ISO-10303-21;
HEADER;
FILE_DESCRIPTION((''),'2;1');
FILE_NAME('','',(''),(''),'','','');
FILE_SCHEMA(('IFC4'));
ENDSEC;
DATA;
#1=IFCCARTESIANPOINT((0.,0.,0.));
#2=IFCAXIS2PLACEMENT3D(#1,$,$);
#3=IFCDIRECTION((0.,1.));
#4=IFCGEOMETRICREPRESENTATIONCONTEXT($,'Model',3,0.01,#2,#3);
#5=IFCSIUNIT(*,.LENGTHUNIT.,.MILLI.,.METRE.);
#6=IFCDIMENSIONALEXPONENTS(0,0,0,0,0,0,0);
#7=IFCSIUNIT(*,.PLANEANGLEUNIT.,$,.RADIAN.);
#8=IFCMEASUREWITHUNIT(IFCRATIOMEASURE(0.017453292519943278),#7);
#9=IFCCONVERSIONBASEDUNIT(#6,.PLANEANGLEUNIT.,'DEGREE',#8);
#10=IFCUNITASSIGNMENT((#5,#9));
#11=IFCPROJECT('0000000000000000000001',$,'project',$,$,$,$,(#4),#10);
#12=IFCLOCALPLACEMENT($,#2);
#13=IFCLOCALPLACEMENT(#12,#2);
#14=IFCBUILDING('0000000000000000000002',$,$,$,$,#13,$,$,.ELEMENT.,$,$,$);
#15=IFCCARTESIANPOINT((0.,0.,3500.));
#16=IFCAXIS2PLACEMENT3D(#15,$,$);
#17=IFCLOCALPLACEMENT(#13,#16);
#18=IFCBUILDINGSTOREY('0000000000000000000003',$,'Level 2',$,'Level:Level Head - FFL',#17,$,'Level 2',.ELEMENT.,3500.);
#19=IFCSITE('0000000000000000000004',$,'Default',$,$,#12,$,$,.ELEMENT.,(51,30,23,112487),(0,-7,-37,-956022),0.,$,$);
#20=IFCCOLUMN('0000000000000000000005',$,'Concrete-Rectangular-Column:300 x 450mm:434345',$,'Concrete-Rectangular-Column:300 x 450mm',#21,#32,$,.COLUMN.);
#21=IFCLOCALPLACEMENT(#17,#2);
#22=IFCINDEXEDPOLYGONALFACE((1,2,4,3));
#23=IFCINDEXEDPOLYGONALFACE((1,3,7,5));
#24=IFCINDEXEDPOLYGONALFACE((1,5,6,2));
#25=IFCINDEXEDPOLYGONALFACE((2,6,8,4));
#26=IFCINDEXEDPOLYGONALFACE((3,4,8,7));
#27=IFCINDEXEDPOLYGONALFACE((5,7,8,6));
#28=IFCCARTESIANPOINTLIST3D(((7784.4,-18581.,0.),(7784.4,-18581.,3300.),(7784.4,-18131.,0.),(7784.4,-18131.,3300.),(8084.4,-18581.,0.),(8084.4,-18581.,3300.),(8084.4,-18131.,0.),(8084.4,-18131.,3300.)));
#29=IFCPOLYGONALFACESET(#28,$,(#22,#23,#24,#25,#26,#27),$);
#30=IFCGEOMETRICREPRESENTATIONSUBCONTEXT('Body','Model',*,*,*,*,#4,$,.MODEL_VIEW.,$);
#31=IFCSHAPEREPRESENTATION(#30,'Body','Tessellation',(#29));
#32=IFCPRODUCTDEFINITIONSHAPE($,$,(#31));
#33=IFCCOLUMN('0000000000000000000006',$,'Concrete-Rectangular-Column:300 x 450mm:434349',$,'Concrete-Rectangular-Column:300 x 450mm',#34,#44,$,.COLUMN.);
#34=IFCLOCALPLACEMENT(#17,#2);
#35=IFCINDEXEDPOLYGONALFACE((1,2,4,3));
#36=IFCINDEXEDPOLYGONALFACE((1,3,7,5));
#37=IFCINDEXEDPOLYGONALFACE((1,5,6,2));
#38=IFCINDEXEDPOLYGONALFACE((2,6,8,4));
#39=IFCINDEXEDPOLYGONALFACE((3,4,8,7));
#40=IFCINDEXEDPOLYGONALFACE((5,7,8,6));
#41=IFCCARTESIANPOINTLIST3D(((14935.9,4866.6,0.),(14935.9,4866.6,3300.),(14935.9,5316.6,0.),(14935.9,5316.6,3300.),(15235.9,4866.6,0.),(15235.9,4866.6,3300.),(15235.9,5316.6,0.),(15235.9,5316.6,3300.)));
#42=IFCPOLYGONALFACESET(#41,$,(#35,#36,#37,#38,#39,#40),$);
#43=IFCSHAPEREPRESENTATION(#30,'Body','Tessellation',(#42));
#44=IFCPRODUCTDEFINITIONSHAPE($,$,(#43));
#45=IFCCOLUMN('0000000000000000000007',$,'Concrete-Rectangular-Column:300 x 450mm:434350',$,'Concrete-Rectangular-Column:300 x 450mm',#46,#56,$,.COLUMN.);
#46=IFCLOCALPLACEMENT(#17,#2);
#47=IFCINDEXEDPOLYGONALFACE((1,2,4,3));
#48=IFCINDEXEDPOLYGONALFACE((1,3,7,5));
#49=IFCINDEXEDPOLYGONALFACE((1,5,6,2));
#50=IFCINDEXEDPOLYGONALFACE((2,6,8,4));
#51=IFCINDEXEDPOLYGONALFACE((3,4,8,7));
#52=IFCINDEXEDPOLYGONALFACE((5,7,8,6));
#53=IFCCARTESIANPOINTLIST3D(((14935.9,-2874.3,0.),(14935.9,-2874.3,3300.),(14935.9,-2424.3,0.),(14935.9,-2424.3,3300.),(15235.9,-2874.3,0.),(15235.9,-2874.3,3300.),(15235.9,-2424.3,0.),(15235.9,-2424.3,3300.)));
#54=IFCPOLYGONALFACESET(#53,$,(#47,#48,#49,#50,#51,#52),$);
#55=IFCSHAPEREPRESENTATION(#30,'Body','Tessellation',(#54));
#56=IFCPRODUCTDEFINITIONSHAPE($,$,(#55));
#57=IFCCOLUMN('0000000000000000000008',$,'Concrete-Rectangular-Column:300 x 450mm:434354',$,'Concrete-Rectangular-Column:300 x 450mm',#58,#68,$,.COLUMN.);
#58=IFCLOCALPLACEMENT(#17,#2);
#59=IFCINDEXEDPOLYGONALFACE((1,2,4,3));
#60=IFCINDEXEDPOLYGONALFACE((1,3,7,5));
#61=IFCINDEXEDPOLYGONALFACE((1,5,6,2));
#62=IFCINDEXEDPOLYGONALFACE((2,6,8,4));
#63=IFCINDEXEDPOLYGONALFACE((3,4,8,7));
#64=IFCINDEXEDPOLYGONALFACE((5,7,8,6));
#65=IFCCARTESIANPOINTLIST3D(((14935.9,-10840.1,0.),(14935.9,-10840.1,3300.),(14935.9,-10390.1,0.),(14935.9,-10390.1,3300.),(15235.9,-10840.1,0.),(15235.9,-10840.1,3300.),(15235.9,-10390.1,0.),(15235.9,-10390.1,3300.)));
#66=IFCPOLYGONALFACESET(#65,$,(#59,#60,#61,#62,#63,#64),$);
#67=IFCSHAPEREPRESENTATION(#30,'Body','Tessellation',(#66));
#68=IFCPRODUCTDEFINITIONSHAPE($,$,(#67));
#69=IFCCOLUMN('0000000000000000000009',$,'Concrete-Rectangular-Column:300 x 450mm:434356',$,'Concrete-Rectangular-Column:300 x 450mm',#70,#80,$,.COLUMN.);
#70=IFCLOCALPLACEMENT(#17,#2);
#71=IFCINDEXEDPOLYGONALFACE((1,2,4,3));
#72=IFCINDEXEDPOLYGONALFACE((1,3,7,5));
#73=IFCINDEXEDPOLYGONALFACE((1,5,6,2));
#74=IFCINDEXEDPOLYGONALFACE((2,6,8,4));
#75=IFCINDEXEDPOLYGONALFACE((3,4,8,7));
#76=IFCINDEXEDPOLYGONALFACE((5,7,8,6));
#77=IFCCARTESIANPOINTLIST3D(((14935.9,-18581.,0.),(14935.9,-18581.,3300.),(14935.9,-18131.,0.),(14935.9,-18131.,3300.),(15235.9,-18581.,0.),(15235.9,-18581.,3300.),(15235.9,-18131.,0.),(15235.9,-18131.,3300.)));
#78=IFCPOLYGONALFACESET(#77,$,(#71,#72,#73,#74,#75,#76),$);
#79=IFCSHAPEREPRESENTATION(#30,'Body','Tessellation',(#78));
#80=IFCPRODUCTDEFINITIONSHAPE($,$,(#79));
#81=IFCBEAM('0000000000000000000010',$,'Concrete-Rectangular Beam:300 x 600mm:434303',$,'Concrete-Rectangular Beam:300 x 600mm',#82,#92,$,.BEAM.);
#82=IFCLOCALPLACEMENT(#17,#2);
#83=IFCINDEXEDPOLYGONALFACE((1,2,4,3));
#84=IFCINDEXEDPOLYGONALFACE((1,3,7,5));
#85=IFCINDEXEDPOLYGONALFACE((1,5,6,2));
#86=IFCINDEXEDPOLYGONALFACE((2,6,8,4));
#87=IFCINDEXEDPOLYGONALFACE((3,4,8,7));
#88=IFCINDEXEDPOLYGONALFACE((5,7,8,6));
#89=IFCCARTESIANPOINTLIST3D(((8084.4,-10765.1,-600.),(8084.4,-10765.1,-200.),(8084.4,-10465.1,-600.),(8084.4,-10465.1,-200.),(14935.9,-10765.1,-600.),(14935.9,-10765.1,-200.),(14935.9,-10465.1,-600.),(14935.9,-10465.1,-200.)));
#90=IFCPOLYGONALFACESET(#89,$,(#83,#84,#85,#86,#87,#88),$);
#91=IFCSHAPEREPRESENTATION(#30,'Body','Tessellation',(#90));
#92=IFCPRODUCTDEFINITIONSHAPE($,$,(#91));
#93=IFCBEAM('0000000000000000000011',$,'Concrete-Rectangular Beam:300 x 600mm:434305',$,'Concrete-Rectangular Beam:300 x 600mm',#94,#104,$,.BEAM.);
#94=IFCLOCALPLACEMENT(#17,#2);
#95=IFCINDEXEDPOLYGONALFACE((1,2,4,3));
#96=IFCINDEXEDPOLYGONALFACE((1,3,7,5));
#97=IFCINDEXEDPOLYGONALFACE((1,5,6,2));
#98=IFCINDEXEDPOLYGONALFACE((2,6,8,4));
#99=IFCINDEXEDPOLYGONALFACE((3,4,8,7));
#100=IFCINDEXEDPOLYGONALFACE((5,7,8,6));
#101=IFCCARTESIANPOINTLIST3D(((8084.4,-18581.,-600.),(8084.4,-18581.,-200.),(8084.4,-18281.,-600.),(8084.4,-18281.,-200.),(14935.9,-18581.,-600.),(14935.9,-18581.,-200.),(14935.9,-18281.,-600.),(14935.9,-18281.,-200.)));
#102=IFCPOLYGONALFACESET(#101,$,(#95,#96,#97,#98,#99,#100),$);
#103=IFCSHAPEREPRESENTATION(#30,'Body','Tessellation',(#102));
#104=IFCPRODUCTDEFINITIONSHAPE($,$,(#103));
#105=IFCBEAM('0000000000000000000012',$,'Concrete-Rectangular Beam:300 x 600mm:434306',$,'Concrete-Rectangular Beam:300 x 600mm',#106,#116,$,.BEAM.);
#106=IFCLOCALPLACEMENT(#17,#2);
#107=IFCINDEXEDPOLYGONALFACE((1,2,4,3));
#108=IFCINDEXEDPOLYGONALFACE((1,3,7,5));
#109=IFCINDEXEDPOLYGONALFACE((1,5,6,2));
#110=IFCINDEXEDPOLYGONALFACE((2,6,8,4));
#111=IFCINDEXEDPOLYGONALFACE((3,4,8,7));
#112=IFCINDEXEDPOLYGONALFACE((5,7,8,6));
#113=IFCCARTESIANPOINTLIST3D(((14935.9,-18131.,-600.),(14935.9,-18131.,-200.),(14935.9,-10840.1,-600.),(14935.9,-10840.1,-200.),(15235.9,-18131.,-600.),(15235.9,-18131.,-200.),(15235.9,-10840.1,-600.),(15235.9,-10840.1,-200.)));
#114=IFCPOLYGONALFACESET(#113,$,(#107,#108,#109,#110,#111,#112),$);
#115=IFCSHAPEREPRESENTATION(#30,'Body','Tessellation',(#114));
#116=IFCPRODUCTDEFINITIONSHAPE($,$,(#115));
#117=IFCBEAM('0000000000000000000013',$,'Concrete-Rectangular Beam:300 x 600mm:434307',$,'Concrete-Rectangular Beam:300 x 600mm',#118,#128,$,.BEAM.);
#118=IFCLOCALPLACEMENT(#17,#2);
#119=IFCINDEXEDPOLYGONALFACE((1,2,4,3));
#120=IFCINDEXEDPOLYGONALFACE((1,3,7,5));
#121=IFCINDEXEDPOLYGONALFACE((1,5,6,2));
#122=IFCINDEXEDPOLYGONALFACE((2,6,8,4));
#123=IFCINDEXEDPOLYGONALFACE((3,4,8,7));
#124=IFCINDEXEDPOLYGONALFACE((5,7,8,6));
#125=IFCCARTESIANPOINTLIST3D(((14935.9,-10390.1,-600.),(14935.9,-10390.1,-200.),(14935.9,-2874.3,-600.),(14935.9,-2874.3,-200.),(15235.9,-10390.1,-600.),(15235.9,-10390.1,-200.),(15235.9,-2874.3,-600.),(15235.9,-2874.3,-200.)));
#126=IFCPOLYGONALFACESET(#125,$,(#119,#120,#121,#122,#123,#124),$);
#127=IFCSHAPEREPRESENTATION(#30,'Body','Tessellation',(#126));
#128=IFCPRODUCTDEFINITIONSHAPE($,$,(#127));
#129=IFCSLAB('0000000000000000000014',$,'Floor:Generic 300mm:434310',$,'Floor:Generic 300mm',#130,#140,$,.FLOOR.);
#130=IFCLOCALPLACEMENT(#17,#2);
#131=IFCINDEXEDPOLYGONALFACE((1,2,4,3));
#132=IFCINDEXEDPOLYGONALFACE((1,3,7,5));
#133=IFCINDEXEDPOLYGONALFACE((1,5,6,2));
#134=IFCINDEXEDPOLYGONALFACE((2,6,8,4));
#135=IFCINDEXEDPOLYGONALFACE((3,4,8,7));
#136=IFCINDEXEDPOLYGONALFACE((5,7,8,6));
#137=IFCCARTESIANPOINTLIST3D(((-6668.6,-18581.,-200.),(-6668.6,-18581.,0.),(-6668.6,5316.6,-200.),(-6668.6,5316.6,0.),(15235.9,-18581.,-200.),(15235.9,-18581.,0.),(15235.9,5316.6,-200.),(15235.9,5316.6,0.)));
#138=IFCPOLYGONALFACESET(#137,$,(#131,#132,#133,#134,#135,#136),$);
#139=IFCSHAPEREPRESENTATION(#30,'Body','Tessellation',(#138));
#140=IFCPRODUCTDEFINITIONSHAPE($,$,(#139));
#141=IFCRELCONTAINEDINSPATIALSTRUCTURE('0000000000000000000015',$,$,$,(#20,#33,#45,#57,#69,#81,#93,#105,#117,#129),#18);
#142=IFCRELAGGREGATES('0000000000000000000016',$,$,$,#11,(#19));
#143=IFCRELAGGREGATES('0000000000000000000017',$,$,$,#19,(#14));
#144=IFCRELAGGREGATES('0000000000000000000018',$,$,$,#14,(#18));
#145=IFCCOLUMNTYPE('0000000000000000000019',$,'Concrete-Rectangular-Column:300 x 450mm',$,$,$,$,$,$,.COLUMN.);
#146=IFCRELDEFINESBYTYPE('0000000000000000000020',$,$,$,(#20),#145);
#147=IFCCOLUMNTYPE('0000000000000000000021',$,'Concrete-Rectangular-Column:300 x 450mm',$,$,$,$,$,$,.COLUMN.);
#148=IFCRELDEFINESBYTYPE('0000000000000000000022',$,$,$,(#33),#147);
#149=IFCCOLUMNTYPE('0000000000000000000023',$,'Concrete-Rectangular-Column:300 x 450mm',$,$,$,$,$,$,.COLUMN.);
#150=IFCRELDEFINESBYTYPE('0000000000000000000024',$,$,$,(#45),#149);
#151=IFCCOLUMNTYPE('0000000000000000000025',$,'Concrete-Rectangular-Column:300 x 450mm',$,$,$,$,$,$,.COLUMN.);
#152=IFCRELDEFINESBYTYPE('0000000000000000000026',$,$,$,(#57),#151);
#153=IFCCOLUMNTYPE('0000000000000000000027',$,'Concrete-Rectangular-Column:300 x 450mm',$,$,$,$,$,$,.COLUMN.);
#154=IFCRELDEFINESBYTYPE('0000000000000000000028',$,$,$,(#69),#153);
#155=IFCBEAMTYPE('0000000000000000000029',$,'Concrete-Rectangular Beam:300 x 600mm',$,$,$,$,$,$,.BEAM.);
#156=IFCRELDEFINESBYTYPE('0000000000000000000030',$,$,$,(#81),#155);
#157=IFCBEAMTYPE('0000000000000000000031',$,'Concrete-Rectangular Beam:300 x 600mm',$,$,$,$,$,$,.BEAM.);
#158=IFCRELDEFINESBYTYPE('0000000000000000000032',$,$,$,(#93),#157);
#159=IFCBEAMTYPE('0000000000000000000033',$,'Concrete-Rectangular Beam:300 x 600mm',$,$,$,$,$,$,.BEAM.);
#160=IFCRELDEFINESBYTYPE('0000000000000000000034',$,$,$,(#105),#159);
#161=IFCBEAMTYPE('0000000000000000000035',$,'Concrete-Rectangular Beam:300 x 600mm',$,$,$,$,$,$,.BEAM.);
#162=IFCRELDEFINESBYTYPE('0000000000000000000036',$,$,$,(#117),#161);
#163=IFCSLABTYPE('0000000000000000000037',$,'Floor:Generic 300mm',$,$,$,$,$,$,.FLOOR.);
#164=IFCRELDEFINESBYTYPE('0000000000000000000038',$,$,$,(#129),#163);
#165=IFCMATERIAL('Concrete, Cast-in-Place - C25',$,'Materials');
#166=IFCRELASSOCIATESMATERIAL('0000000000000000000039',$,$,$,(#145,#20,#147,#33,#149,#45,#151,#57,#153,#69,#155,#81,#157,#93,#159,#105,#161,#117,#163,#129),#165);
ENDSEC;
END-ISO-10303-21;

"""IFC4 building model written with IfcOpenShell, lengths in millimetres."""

from ifc_helpers import new_model, entity, si_unit, converted_unit, direction, frame, origin, place, context, subcontext, project, spatial, indexed_curve, outline, extrude, source, transform, mapped, material, type_object, type_shapes, element, save


model = new_model("IFC4")

# Units and contexts
model_context = context("Model", 3, precision=0.01, world=origin(), true_north=direction((0.0, 1.0)))
body_context = subcontext(model_context, "Body", "Model", "MODEL_VIEW")
ifc_project = project(units=[si_unit("LENGTHUNIT", "METRE", prefix="MILLI"), converted_unit("PLANEANGLEUNIT", "DEGREE", entity("IfcRatioMeasure", 0.017453292519943278), si_unit("PLANEANGLEUNIT", "RADIAN"), dimensions=[0, 0, 0, 0, 0, 0, 0])], contexts=[model_context])

# Site, building, storey
site_placement = place(None, origin())
site = spatial("IfcSite", under=ifc_project, at=site_placement, Name="Default", CompositionType="ELEMENT", RefLatitude=(51, 30, 23, 112487), RefLongitude=(0, -7, -37, -956022), RefElevation=0.0)
building_placement = place(site_placement, origin())
building = spatial("IfcBuilding", under=site, at=building_placement, CompositionType="ELEMENT")
storey_placement = place(building_placement, frame((0.0, 0.0, 3500.0)))
storey = spatial("IfcBuildingStorey", under=building, at=storey_placement, Name="Level 2", ObjectType="Level:Level Head - FFL", LongName="Level 2", CompositionType="ELEMENT", Elevation=3500.0)

# Columns
ifc_material = material(Name="Concrete, Cast-in-Place - C25", Category="Materials")
column_type_1 = type_object("IfcColumnType", Name="Concrete-Rectangular-Column:300 x 450mm", PredefinedType="COLUMN", material=ifc_material)
shared_shape_1 = source(origin(), body_context, "Body", "SweptSolid", [
    extrude(outline(indexed_curve([(-225.0, -150.0), (225.0, -150.0), (225.0, 150.0), (-225.0, 150.0), (-225.0, -150.0)], self_intersect=False)), frame((7934.4, -18356.0, 3500.0), z_axis=(0.0, 0.0, 1.0), x_axis=(0.0, -1.0, 0.0)), (0.0, 0.0, 1.0), 3300.0),
])
type_shapes(column_type_1, [shared_shape_1])
column_1_placement = place(storey_placement, frame((0.0, 0.0, -3500.0)))
element("IfcColumn", 1, at=column_1_placement, inside=storey, type_object=column_type_1, material=ifc_material, Name="Concrete-Rectangular-Column:300 x 450mm:434345", ObjectType="Concrete-Rectangular-Column:300 x 450mm", PredefinedType="COLUMN", context=body_context, shape_type="MappedRepresentation", body=[
    mapped(shared_shape_1, transform((0.0, 0.0, 0.0), scale=1.0)),
])
column_type_2 = type_object("IfcColumnType", Name="Concrete-Rectangular-Column:300 x 450mm", PredefinedType="COLUMN", material=ifc_material)
shared_shape_2 = source(origin(), body_context, "Body", "SweptSolid", [
    extrude(outline(indexed_curve([(-225.0, -150.0), (225.0, -150.0), (225.0, 150.0), (-225.0, 150.0), (-225.0, -150.0)], self_intersect=False)), frame((15085.9, 5091.6, 3500.0), z_axis=(0.0, 0.0, 1.0), x_axis=(0.0, -1.0, 0.0)), (0.0, 0.0, 1.0), 3300.0),
])
type_shapes(column_type_2, [shared_shape_2])
column_2_placement = place(storey_placement, frame((0.0, 0.0, -3500.0)))
element("IfcColumn", 2, at=column_2_placement, inside=storey, type_object=column_type_2, material=ifc_material, Name="Concrete-Rectangular-Column:300 x 450mm:434349", ObjectType="Concrete-Rectangular-Column:300 x 450mm", PredefinedType="COLUMN", context=body_context, shape_type="MappedRepresentation", body=[
    mapped(shared_shape_2, transform((0.0, 0.0, 0.0), scale=1.0)),
])
column_type_3 = type_object("IfcColumnType", Name="Concrete-Rectangular-Column:300 x 450mm", PredefinedType="COLUMN", material=ifc_material)
shared_shape_3 = source(origin(), body_context, "Body", "SweptSolid", [
    extrude(outline(indexed_curve([(-225.0, -150.0), (225.0, -150.0), (225.0, 150.0), (-225.0, 150.0), (-225.0, -150.0)], self_intersect=False)), frame((15085.9, -2649.3, 3500.0), z_axis=(0.0, 0.0, 1.0), x_axis=(0.0, -1.0, 0.0)), (0.0, 0.0, 1.0), 3300.0),
])
type_shapes(column_type_3, [shared_shape_3])
column_3_placement = place(storey_placement, frame((0.0, 0.0, -3500.0)))
element("IfcColumn", 3, at=column_3_placement, inside=storey, type_object=column_type_3, material=ifc_material, Name="Concrete-Rectangular-Column:300 x 450mm:434350", ObjectType="Concrete-Rectangular-Column:300 x 450mm", PredefinedType="COLUMN", context=body_context, shape_type="MappedRepresentation", body=[
    mapped(shared_shape_3, transform((0.0, 0.0, 0.0), scale=1.0)),
])
column_type_4 = type_object("IfcColumnType", Name="Concrete-Rectangular-Column:300 x 450mm", PredefinedType="COLUMN", material=ifc_material)
shared_shape_4 = source(origin(), body_context, "Body", "SweptSolid", [
    extrude(outline(indexed_curve([(-225.0, -150.0), (225.0, -150.0), (225.0, 150.0), (-225.0, 150.0), (-225.0, -150.0)], self_intersect=False)), frame((15085.9, -10615.1, 3500.0), z_axis=(0.0, 0.0, 1.0), x_axis=(0.0, -1.0, 0.0)), (0.0, 0.0, 1.0), 3300.0),
])
type_shapes(column_type_4, [shared_shape_4])
column_4_placement = place(storey_placement, frame((0.0, 0.0, -3500.0)))
element("IfcColumn", 4, at=column_4_placement, inside=storey, type_object=column_type_4, material=ifc_material, Name="Concrete-Rectangular-Column:300 x 450mm:434354", ObjectType="Concrete-Rectangular-Column:300 x 450mm", PredefinedType="COLUMN", context=body_context, shape_type="MappedRepresentation", body=[
    mapped(shared_shape_4, transform((0.0, 0.0, 0.0), scale=1.0)),
])
column_type_5 = type_object("IfcColumnType", Name="Concrete-Rectangular-Column:300 x 450mm", PredefinedType="COLUMN", material=ifc_material)
shared_shape_5 = source(origin(), body_context, "Body", "SweptSolid", [
    extrude(outline(indexed_curve([(-225.0, -150.0), (225.0, -150.0), (225.0, 150.0), (-225.0, 150.0), (-225.0, -150.0)], self_intersect=False)), frame((15085.9, -18356.0, 3500.0), z_axis=(0.0, 0.0, 1.0), x_axis=(0.0, -1.0, 0.0)), (0.0, 0.0, 1.0), 3300.0),
])
type_shapes(column_type_5, [shared_shape_5])
column_5_placement = place(storey_placement, frame((0.0, 0.0, -3500.0)))
element("IfcColumn", 5, at=column_5_placement, inside=storey, type_object=column_type_5, material=ifc_material, Name="Concrete-Rectangular-Column:300 x 450mm:434356", ObjectType="Concrete-Rectangular-Column:300 x 450mm", PredefinedType="COLUMN", context=body_context, shape_type="MappedRepresentation", body=[
    mapped(shared_shape_5, transform((0.0, 0.0, 0.0), scale=1.0)),
])

# Beams
beam_type_1 = type_object("IfcBeamType", Name="Concrete-Rectangular Beam:300 x 600mm", PredefinedType="BEAM", material=ifc_material)
shared_shape_6 = source(origin(), body_context, "Body", "SweptSolid", [
    extrude(outline(indexed_curve([(-200.0, -150.0), (200.0, -150.0), (200.0, 150.0), (-200.0, 150.0), (-200.0, -150.0)], self_intersect=False)), frame((14935.9, -10615.1, 3100.0), z_axis=(-1.0, 0.0, 0.0), x_axis=(0.0, 0.0, -1.0)), (0.0, 0.0, 1.0), 6851.5),
])
type_shapes(beam_type_1, [shared_shape_6])
beam_1_placement = place(storey_placement, frame((0.0, 0.0, -3500.0)))
element("IfcBeam", 6, at=beam_1_placement, inside=storey, type_object=beam_type_1, material=ifc_material, Name="Concrete-Rectangular Beam:300 x 600mm:434303", ObjectType="Concrete-Rectangular Beam:300 x 600mm", PredefinedType="BEAM", context=body_context, shape_type="MappedRepresentation", body=[
    mapped(shared_shape_6, transform((0.0, 0.0, 0.0), scale=1.0)),
])
beam_type_2 = type_object("IfcBeamType", Name="Concrete-Rectangular Beam:300 x 600mm", PredefinedType="BEAM", material=ifc_material)
shared_shape_7 = source(origin(), body_context, "Body", "SweptSolid", [
    extrude(outline(indexed_curve([(-200.0, -150.0), (200.0, -150.0), (200.0, 150.0), (-200.0, 150.0), (-200.0, -150.0)], self_intersect=False)), frame((14935.9, -18431.0, 3100.0), z_axis=(-1.0, 0.0, 0.0), x_axis=(0.0, 0.0, -1.0)), (0.0, 0.0, 1.0), 6851.5),
])
type_shapes(beam_type_2, [shared_shape_7])
beam_2_placement = place(storey_placement, frame((0.0, 0.0, -3500.0)))
element("IfcBeam", 7, at=beam_2_placement, inside=storey, type_object=beam_type_2, material=ifc_material, Name="Concrete-Rectangular Beam:300 x 600mm:434305", ObjectType="Concrete-Rectangular Beam:300 x 600mm", PredefinedType="BEAM", context=body_context, shape_type="MappedRepresentation", body=[
    mapped(shared_shape_7, transform((0.0, 0.0, 0.0), scale=1.0)),
])
beam_type_3 = type_object("IfcBeamType", Name="Concrete-Rectangular Beam:300 x 600mm", PredefinedType="BEAM", material=ifc_material)
shared_shape_8 = source(origin(), body_context, "Body", "SweptSolid", [
    extrude(outline(indexed_curve([(-150.0, -200.0), (150.0, -200.0), (150.0, 200.0), (-150.0, 200.0), (-150.0, -200.0)], self_intersect=False)), frame((15085.9, -18131.0, 3100.0), z_axis=(0.0, 1.0, 0.0), x_axis=(-1.0, 0.0, 0.0)), (0.0, 0.0, 1.0), 7290.9),
])
type_shapes(beam_type_3, [shared_shape_8])
beam_3_placement = place(storey_placement, frame((0.0, 0.0, -3500.0)))
element("IfcBeam", 8, at=beam_3_placement, inside=storey, type_object=beam_type_3, material=ifc_material, Name="Concrete-Rectangular Beam:300 x 600mm:434306", ObjectType="Concrete-Rectangular Beam:300 x 600mm", PredefinedType="BEAM", context=body_context, shape_type="MappedRepresentation", body=[
    mapped(shared_shape_8, transform((0.0, 0.0, 0.0), scale=1.0)),
])
beam_type_4 = type_object("IfcBeamType", Name="Concrete-Rectangular Beam:300 x 600mm", PredefinedType="BEAM", material=ifc_material)
shared_shape_9 = source(origin(), body_context, "Body", "SweptSolid", [
    extrude(outline(indexed_curve([(-150.0, -200.0), (150.0, -200.0), (150.0, 200.0), (-150.0, 200.0), (-150.0, -200.0)], self_intersect=False)), frame((15085.9, -10390.1, 3100.0), z_axis=(0.0, 1.0, 0.0), x_axis=(-1.0, 0.0, 0.0)), (0.0, 0.0, 1.0), 7515.9),
])
type_shapes(beam_type_4, [shared_shape_9])
beam_4_placement = place(storey_placement, frame((0.0, 0.0, -3500.0)))
element("IfcBeam", 9, at=beam_4_placement, inside=storey, type_object=beam_type_4, material=ifc_material, Name="Concrete-Rectangular Beam:300 x 600mm:434307", ObjectType="Concrete-Rectangular Beam:300 x 600mm", PredefinedType="BEAM", context=body_context, shape_type="MappedRepresentation", body=[
    mapped(shared_shape_9, transform((0.0, 0.0, 0.0), scale=1.0)),
])

# Slab
slab_type = type_object("IfcSlabType", Name="Floor:Generic 300mm", PredefinedType="FLOOR", material=ifc_material)
slab_placement = place(storey_placement, origin())
element("IfcSlab", 10, at=slab_placement, inside=storey, type_object=slab_type, material=ifc_material, Name="Floor:Generic 300mm:434310", ObjectType="Floor:Generic 300mm", PredefinedType="FLOOR", context=body_context, shape_type="SweptSolid", body=[
    extrude(outline(indexed_curve([(-11948.8, -10952.2), (11948.8, -10952.2), (11948.8, 10952.2), (-11948.8, 10952.2), (-11948.8, -10952.2)], self_intersect=False)), frame((4283.6, -6632.2, 0.0), z_axis=(0.0, 0.0, -1.0), x_axis=(0.0, 1.0, 0.0)), (0.0, 0.0, 1.0), 200.0),
])

save(model, "model.ifc")
